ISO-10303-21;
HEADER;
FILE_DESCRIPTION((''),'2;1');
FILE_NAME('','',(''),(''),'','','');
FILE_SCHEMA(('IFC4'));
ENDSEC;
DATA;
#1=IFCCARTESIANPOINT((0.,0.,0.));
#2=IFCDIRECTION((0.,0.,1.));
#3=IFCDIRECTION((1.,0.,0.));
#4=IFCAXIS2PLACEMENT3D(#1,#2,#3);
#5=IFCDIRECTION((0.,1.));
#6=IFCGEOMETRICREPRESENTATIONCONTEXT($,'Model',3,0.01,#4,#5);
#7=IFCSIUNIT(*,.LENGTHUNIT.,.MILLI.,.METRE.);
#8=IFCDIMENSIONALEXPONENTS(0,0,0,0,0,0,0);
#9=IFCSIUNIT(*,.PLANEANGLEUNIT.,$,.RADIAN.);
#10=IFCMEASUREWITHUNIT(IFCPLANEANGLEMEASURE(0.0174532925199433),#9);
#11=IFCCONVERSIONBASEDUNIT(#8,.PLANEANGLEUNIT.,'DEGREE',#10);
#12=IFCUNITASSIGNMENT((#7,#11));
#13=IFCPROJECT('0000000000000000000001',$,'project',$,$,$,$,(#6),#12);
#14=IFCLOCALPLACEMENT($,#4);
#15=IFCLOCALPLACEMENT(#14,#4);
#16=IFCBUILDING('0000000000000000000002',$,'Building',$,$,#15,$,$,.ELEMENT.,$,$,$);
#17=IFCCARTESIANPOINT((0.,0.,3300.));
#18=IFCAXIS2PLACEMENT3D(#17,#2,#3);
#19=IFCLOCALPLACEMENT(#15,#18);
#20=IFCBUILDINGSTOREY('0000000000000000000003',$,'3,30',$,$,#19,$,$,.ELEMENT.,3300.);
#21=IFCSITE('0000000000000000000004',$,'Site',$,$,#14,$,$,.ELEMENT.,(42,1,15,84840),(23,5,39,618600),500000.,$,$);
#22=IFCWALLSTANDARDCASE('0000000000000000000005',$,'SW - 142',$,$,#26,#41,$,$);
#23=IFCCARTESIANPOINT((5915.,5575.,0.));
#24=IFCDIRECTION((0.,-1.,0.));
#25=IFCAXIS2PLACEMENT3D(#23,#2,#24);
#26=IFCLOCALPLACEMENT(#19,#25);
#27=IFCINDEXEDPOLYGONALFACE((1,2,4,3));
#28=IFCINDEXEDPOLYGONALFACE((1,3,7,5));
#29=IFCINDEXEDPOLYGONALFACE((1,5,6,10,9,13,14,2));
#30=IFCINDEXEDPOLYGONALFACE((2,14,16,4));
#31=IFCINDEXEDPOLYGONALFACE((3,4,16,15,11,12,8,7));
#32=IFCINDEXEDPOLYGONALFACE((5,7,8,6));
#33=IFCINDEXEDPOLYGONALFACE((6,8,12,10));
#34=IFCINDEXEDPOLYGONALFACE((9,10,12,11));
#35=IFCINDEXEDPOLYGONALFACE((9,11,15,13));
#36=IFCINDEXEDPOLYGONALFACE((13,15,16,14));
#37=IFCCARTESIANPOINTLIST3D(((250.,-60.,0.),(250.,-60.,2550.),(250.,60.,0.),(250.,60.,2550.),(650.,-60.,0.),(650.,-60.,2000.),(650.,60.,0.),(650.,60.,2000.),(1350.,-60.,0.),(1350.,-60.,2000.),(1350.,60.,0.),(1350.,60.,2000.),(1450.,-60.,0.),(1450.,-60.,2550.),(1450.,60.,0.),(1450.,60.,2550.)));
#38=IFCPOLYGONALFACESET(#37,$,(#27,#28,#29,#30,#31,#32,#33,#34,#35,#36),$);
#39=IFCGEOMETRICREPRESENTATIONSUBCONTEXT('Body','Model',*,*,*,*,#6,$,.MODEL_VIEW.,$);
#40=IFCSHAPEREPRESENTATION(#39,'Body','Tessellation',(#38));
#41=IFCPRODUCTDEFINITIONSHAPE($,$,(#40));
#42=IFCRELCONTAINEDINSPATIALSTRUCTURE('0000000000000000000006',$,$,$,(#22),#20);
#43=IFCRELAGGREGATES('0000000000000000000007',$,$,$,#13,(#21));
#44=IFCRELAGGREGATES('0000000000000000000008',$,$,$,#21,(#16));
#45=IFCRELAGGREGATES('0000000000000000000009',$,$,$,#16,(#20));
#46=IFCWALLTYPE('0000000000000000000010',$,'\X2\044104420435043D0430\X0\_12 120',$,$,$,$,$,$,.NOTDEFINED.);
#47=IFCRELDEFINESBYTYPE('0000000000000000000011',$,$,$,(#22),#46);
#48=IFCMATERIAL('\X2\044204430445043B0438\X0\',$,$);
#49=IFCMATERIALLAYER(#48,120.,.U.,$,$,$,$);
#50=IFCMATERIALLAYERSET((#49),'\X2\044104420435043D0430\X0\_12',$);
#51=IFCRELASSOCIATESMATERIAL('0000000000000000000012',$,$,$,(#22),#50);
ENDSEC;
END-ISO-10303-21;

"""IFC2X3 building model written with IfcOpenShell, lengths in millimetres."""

from ifc_helpers import new_model, entity, si_unit, converted_unit, direction, frame, origin_with_axes, origin_2d_with_axis, place, context, subcontext, project, spatial, polyline, rectangle, outline, extrude, material, layer, layer_set, layer_usage, type_object, element, save


model = new_model("IFC2X3")

# Units and contexts
model_context = context("Model", 3, precision=0.01, world=origin_with_axes(), true_north=direction((0.0, 1.0)))
body_context = subcontext(model_context, "Body", "Model", "MODEL_VIEW")
ifc_project = project(units=[si_unit("LENGTHUNIT", "METRE", prefix="MILLI"), converted_unit("PLANEANGLEUNIT", "DEGREE", entity("IfcPlaneAngleMeasure", 0.0174532925199433), si_unit("PLANEANGLEUNIT", "RADIAN"), dimensions=[0, 0, 0, 0, 0, 0, 0])], contexts=[model_context])

# Site, building, storey
site_placement = place(None, origin_with_axes())
site = spatial("IfcSite", under=ifc_project, at=site_placement, Name="Site", CompositionType="ELEMENT", RefLatitude=(42, 1, 15, 84840), RefLongitude=(23, 5, 39, 618600), RefElevation=500000.0)
building_placement = place(site_placement, origin_with_axes())
building = spatial("IfcBuilding", under=site, at=building_placement, Name="Building", CompositionType="ELEMENT")
storey_placement = place(building_placement, frame((0.0, 0.0, 3300.0), z_axis=(0.0, 0.0, 1.0), x_axis=(1.0, 0.0, 0.0)))
storey = spatial("IfcBuildingStorey", under=building, at=storey_placement, Name="3,30", CompositionType="ELEMENT", Elevation=3300.0)

# Shared definitions
ifc_material_1 = material(Name="тухли")

# Wall, opening
ifc_layer_1 = layer(ifc_material_1, 120.0, ventilated="UNKNOWN")
ifc_layer_set_1 = layer_set([ifc_layer_1], Name="стена_12")
ifc_layer_usage_1 = layer_usage(ifc_layer_set_1, "AXIS2", "NEGATIVE", 60.0)
wall_type_1 = type_object("IfcWallType", Name="стена_12 120", PredefinedType="NOTDEFINED")
wall_1_placement = place(storey_placement, frame((5915.0, 5575.0, 0.0), z_axis=(0.0, 0.0, 1.0), x_axis=(0.0, -1.0, 0.0)))
wall_1 = element("IfcWallStandardCase", 1, at=wall_1_placement, inside=storey, type_object=wall_type_1, material=ifc_layer_usage_1, Name="SW - 142", context=body_context, shape_type="SweptSolid", body=[
    extrude(outline(polyline([(250.0, -60.0), (1450.0, -60.0), (1450.0, 60.0), (250.0, 60.0), (250.0, -60.0)])), origin_with_axes(), (0.0, 0.0, 1.0), 2550.0),
])
opening_1_placement = place(wall_1_placement, frame((1000.0, 0.0, 0.0), z_axis=(0.0, 0.0, 1.0), x_axis=(1.0, 0.0, 0.0)))
element("IfcOpeningElement", 2, at=opening_1_placement, cuts=wall_1, context=body_context, shape_type="SweptSolid", body=[
    extrude(rectangle(XDim=700.0, YDim=2000.0, at=origin_2d_with_axis()), frame((0.0, 120.0, 1000.0), z_axis=(0.0, 1.0, 0.0), x_axis=(1.0, 0.0, 0.0)), (0.0, 0.0, -1.0), 360.0),
])

save(model, "model.ifc")
